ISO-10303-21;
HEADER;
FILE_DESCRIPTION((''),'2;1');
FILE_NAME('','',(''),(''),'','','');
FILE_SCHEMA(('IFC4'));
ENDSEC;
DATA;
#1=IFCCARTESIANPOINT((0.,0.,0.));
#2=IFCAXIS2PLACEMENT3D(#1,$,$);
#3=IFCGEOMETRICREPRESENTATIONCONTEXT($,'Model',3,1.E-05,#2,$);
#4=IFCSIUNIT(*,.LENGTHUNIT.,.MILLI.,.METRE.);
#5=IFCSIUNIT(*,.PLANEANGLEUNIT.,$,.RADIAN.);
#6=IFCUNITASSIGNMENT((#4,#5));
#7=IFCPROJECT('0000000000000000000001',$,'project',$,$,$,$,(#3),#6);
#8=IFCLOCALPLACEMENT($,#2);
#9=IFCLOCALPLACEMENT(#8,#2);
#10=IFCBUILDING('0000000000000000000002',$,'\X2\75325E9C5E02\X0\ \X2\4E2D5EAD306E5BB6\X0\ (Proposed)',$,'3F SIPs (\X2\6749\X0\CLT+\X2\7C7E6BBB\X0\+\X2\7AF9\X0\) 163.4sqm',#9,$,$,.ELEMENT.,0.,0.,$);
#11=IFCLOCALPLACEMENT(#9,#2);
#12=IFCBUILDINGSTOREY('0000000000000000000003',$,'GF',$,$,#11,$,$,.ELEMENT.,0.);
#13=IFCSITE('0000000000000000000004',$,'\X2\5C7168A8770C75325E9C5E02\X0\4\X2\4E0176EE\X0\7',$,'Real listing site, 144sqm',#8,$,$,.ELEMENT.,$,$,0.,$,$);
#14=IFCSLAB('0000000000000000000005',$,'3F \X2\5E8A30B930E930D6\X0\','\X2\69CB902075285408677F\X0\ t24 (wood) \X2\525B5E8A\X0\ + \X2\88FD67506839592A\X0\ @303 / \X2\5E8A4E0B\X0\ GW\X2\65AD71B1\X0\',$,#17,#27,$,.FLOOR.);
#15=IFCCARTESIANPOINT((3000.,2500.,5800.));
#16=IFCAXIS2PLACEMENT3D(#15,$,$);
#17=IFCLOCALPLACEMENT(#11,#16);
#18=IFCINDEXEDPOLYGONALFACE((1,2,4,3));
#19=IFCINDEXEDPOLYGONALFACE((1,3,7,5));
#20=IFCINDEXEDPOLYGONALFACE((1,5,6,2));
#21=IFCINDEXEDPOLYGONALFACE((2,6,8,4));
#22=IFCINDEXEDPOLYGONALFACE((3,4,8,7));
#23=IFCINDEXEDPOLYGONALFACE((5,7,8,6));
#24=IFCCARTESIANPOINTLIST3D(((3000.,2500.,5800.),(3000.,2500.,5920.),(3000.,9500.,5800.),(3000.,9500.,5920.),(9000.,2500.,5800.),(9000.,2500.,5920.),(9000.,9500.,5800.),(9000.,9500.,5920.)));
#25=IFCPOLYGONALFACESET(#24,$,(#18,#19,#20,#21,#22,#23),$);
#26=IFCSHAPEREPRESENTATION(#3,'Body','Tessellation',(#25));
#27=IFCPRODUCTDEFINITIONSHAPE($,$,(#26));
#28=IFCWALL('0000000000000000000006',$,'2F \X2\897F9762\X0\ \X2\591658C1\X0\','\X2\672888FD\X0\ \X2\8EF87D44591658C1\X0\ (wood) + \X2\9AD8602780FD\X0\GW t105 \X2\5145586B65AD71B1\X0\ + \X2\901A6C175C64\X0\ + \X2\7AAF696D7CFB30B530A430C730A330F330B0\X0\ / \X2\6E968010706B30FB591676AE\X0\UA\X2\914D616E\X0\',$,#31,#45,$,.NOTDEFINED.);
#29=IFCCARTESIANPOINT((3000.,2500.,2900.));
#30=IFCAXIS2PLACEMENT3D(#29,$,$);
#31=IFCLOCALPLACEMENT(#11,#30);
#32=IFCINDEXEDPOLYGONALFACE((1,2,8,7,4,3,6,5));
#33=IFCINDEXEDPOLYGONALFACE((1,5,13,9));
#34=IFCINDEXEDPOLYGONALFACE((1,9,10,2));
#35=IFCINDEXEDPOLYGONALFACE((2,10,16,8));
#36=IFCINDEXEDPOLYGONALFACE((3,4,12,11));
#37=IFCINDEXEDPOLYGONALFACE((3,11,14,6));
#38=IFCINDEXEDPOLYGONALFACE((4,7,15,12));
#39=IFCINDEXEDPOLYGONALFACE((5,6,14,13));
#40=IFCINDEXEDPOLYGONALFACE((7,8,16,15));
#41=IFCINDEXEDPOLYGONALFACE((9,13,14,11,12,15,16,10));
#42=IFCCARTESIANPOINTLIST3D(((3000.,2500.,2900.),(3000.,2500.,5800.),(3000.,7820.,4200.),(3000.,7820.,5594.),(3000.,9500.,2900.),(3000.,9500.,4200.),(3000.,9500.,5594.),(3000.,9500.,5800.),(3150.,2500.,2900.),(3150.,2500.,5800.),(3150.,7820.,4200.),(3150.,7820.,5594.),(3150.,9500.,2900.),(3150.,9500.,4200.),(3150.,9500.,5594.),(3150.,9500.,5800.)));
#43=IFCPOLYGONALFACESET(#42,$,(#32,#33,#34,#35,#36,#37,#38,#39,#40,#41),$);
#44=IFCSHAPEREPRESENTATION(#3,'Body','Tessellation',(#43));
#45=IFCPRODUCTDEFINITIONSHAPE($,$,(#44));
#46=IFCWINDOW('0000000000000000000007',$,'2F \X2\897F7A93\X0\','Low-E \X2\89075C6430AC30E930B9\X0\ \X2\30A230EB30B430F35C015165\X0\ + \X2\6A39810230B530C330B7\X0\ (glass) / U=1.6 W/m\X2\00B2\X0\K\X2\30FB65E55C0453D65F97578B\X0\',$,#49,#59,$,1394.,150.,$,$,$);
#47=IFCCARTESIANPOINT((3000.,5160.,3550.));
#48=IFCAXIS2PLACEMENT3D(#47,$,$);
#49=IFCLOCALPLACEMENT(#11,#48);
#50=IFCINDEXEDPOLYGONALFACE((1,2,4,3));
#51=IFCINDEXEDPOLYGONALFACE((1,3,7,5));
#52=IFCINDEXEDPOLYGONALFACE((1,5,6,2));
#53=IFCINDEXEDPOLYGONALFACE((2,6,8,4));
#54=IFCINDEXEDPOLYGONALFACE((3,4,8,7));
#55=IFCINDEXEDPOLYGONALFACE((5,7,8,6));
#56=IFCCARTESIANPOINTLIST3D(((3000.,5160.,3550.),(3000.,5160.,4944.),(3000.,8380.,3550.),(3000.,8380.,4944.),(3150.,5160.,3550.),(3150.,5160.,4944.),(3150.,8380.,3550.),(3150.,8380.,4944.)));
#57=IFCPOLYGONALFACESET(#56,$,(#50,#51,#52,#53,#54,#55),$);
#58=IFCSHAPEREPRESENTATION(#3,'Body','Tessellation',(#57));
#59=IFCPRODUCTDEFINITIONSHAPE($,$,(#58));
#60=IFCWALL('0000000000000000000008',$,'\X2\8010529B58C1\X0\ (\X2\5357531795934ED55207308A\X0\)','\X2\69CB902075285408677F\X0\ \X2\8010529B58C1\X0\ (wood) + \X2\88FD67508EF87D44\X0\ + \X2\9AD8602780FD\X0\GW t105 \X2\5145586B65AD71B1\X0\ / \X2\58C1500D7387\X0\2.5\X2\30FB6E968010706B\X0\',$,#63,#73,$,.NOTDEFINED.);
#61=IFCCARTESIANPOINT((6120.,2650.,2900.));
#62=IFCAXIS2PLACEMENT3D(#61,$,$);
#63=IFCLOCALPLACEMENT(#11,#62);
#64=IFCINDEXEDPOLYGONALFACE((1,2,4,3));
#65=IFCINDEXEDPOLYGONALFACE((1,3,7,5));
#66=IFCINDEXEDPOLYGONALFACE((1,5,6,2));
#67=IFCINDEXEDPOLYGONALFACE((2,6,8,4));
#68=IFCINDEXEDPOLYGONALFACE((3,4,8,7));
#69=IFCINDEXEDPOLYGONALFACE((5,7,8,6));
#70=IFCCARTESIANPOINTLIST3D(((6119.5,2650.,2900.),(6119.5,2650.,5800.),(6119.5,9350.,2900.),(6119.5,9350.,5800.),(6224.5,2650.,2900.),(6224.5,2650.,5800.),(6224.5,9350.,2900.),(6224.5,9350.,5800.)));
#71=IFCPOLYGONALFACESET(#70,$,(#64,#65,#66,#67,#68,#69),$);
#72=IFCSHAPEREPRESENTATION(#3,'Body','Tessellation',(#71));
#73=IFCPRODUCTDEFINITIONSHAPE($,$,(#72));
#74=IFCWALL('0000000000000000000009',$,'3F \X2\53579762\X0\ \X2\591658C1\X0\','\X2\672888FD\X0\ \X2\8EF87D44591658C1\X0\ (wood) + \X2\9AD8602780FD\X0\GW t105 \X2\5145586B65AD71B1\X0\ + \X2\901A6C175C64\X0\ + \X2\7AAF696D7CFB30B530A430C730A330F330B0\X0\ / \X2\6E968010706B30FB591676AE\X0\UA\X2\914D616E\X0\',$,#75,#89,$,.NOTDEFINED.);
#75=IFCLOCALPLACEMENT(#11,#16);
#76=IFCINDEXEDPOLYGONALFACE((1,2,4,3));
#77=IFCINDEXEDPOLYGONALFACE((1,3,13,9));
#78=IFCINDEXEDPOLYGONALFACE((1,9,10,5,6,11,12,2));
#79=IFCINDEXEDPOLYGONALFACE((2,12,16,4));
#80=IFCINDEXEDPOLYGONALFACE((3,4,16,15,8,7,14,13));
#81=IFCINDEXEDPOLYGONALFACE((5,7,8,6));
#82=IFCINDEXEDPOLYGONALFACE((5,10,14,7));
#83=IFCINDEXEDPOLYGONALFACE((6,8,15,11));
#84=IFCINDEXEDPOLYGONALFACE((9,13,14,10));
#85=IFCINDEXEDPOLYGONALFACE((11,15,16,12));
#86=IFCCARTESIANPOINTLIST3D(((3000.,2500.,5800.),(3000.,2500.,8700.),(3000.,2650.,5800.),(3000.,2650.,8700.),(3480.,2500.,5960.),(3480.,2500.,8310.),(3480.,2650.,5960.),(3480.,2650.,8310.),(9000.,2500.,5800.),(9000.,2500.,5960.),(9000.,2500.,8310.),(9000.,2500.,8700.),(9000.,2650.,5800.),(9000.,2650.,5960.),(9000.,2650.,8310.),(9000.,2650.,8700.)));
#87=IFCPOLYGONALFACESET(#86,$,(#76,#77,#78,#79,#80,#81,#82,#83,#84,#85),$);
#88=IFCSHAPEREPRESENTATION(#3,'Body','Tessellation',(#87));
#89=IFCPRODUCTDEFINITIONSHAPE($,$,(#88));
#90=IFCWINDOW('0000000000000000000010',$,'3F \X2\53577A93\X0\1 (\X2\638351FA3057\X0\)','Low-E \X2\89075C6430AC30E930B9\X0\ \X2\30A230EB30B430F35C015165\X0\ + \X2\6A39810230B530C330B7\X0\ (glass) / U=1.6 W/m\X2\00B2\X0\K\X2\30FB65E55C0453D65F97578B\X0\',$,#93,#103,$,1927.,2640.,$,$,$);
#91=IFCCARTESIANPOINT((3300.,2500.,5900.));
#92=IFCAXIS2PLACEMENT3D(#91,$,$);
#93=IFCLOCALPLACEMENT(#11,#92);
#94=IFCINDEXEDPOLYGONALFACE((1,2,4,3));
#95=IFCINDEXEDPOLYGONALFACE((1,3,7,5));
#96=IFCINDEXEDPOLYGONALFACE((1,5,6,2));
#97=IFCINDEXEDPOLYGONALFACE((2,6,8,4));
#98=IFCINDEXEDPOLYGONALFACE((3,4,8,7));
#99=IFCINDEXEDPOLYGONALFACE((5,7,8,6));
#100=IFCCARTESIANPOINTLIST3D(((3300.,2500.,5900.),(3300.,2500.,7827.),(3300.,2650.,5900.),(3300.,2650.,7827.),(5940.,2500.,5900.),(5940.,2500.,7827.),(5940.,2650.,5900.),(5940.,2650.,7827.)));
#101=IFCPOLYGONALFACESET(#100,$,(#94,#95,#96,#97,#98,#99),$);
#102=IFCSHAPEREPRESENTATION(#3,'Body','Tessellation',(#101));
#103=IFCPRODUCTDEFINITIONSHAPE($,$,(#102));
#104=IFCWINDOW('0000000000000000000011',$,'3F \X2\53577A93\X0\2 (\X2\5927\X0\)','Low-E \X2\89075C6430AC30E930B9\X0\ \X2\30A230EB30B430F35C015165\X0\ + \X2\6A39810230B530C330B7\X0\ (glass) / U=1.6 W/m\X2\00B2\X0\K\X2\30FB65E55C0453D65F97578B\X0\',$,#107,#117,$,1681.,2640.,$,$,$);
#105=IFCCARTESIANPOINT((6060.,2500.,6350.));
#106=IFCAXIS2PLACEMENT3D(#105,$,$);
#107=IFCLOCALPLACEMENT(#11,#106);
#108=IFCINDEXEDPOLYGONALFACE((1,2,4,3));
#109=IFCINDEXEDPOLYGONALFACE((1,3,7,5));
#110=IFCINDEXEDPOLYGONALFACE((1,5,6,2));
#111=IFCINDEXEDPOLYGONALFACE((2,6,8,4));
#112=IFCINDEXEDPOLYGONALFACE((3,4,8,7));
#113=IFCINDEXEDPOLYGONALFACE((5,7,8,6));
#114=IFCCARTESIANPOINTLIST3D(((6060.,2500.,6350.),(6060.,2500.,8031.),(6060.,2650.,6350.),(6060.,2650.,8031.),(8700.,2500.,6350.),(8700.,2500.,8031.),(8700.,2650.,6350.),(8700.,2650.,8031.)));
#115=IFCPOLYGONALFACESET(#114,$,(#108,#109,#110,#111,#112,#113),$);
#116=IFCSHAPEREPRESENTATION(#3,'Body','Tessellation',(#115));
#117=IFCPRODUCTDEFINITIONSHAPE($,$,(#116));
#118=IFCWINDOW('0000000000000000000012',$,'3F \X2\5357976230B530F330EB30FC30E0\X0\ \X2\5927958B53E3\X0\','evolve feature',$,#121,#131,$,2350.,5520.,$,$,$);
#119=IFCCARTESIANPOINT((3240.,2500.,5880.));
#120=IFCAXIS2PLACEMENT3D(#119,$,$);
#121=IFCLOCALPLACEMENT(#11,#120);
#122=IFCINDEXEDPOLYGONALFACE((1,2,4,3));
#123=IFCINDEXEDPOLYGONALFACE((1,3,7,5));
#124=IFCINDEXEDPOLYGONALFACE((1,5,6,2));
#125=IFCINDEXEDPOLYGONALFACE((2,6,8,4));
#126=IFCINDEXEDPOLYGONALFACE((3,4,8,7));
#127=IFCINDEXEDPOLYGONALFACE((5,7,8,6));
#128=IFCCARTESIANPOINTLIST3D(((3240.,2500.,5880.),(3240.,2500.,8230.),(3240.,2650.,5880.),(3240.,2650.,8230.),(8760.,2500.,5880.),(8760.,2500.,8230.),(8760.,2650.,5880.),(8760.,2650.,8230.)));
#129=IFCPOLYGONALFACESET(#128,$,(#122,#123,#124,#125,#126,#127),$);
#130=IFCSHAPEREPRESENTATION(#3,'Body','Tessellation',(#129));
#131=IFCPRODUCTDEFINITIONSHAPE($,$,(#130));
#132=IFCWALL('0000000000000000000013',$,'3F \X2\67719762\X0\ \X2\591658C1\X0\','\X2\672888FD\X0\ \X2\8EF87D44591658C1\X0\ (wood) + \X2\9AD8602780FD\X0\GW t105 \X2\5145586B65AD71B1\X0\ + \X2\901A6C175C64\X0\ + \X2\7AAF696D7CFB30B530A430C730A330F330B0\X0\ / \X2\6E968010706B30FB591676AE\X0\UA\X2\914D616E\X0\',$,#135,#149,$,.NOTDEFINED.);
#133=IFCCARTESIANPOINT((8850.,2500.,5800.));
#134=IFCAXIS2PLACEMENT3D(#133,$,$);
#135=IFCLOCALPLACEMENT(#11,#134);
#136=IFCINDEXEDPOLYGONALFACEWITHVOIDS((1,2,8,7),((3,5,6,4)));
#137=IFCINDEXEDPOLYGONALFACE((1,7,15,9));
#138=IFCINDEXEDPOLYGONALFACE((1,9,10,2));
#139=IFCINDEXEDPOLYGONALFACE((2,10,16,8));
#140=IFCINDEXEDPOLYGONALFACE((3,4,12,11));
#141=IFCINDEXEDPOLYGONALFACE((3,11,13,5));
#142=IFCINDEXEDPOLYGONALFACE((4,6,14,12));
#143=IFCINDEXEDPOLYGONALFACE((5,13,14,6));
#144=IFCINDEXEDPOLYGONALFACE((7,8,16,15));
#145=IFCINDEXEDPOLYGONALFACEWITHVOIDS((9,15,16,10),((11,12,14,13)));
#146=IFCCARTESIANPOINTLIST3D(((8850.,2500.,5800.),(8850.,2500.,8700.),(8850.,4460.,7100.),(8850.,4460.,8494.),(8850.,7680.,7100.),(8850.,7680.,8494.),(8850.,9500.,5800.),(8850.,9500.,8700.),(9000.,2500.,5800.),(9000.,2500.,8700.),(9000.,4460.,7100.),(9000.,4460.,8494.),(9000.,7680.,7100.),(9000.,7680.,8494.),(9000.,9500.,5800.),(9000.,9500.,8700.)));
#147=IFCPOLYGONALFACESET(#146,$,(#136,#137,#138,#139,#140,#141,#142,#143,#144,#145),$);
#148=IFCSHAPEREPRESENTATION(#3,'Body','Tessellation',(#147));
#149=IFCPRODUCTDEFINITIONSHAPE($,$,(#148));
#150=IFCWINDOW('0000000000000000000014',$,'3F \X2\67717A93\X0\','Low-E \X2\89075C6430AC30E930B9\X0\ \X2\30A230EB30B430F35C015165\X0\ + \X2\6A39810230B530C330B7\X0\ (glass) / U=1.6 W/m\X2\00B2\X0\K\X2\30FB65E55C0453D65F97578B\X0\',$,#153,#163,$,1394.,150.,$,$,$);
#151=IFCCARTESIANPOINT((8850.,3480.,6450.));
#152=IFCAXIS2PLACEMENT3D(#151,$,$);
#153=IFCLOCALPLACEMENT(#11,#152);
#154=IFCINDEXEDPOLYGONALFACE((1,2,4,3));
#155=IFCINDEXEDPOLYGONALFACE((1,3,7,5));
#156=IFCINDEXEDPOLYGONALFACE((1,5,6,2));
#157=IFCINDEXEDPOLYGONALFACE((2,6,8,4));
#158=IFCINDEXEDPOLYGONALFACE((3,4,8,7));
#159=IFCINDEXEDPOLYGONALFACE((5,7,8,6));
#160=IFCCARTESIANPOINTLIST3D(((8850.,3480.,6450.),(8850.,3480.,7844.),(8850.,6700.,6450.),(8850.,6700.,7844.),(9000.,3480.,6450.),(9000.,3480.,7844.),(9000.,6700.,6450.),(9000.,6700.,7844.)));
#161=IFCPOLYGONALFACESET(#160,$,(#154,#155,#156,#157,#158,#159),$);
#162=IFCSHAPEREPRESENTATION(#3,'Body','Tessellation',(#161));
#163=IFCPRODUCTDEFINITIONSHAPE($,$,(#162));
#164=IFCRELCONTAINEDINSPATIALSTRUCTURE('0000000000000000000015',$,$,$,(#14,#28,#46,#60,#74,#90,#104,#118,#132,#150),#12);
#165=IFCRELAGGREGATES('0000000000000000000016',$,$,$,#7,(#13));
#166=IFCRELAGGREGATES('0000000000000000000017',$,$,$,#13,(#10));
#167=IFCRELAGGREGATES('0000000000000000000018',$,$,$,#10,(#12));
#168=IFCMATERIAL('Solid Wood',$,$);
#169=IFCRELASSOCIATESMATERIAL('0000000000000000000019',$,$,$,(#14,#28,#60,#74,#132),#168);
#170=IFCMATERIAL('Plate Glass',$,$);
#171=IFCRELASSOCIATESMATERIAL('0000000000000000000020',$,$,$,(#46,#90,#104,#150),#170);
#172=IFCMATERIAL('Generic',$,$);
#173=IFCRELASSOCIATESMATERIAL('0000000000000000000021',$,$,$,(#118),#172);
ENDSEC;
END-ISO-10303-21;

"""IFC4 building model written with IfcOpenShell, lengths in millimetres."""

from ifc_helpers import new_model, si_unit, frame, frame_2d, origin, place, context, project, spatial, rectangle, extrude, material, element, fill, save


model = new_model("IFC4")

# Units and contexts
model_context = context("Model", 3, precision=1e-05, world=origin())
ifc_project = project(units=[si_unit("LENGTHUNIT", "METRE", prefix="MILLI"), si_unit("PLANEANGLEUNIT", "RADIAN")], contexts=[model_context])

# Site, building, storey
site_placement = place(None, origin())
site = spatial("IfcSite", under=ifc_project, at=site_placement, Name="山梨県甲府市4丁目7", ObjectType="Real listing site, 144sqm", CompositionType="ELEMENT", RefElevation=0.0)
building_placement = place(site_placement, origin())
building = spatial("IfcBuilding", under=site, at=building_placement, Name="甲府市 中庭の家 (Proposed)", ObjectType="3F SIPs (杉CLT+籾殻+竹) 163.4sqm", CompositionType="ELEMENT", ElevationOfRefHeight=0.0, ElevationOfTerrain=0.0)
storey_placement = place(building_placement, origin())
storey = spatial("IfcBuildingStorey", under=building, at=storey_placement, Name="GF", CompositionType="ELEMENT", Elevation=0.0)

# Slab
ifc_material_1 = material(Name="Solid Wood")
slab_placement = place(storey_placement, frame((3000.0, 2500.0, 5800.0)))
element("IfcSlab", 1, at=slab_placement, inside=storey, material=ifc_material_1, Name="3F 床スラブ", Description="構造用合板 t24 (wood) 剛床 + 製材根太 @303 / 床下 GW断熱", PredefinedType="FLOOR", context=model_context, shape_type="SweptSolid", body=[
    extrude(rectangle(XDim=6000.0, YDim=7000.0, at=frame_2d((3000.0, 3500.0))), frame((3000.0, 2500.0, 5800.0)), (0.0, 0.0, 1.0), 120.0),
])

# Wall, opening, window
wall_1_placement = place(storey_placement, frame((3000.0, 2500.0, 2900.0)))
wall_1 = element("IfcWall", 2, at=wall_1_placement, inside=storey, material=ifc_material_1, Name="2F 西面 外壁", Description="木製 軸組外壁 (wood) + 高性能GW t105 充填断熱 + 通気層 + 窯業系サイディング / 準耐火・外皮UA配慮", PredefinedType="NOTDEFINED", context=model_context, shape_type="SweptSolid", body=[
    extrude(rectangle(XDim=150.0, YDim=7000.0, at=frame_2d((75.0, 3500.0))), frame((3000.0, 2500.0, 2900.0)), (0.0, 0.0, 1.0), 2900.0),
])
opening_1_placement = place(storey_placement, frame((3000.0, 5160.0, 3550.0)))
opening_1 = element("IfcOpeningElement", 3, at=opening_1_placement, cuts=wall_1, PredefinedType="NOTDEFINED", context=model_context, shape_type="SweptSolid", body=[
    extrude(rectangle(XDim=150.0, YDim=3220.0, at=frame_2d((75.0, 1610.0))), frame((3000.0, 5160.0, 3550.0)), (0.0, 0.0, 1.0), 1394.0),
])
ifc_material_2 = material(Name="Plate Glass")
window_1_placement = place(storey_placement, frame((3000.0, 5160.0, 3550.0)))
window_1 = element("IfcWindow", 4, at=window_1_placement, inside=storey, material=ifc_material_2, Name="2F 西窓", Description="Low-E 複層ガラス アルゴン封入 + 樹脂サッシ (glass) / U=1.6 W/m²K・日射取得型", OverallHeight=1394.0, OverallWidth=150.0, context=model_context, shape_type="SweptSolid", body=[
    extrude(rectangle(XDim=150.0, YDim=3220.0, at=frame_2d((75.0, 1610.0))), frame((3000.0, 5160.0, 3550.0)), (0.0, 0.0, 1.0), 1394.0),
])
fill(opening_1, window_1)

# Wall
wall_2_placement = place(storey_placement, frame((6120.0, 2650.0, 2900.0)))
element("IfcWall", 5, at=wall_2_placement, inside=storey, material=ifc_material_1, Name="耐力壁 (南北間仕切り)", Description="構造用合板 耐力壁 (wood) + 製材軸組 + 高性能GW t105 充填断熱 / 壁倍率2.5・準耐火", PredefinedType="NOTDEFINED", context=model_context, shape_type="SweptSolid", body=[
    extrude(rectangle(XDim=105.0, YDim=6700.0, at=frame_2d((52.0, 3350.0))), frame((6120.0, 2650.0, 2900.0)), (0.0, 0.0, 1.0), 2900.0),
])

# Wall, openings, windows
wall_3_placement = place(storey_placement, frame((3000.0, 2500.0, 5800.0)))
wall_3 = element("IfcWall", 6, at=wall_3_placement, inside=storey, material=ifc_material_1, Name="3F 南面 外壁", Description="木製 軸組外壁 (wood) + 高性能GW t105 充填断熱 + 通気層 + 窯業系サイディング / 準耐火・外皮UA配慮", PredefinedType="NOTDEFINED", context=model_context, shape_type="SweptSolid", body=[
    extrude(rectangle(XDim=6000.0, YDim=150.0, at=frame_2d((3000.0, 75.0))), frame((3000.0, 2500.0, 5800.0)), (0.0, 0.0, 1.0), 2900.0),
])
opening_2_placement = place(storey_placement, frame((3300.0, 2500.0, 5900.0)))
opening_2 = element("IfcOpeningElement", 7, at=opening_2_placement, cuts=wall_3, PredefinedType="NOTDEFINED", context=model_context, shape_type="SweptSolid", body=[
    extrude(rectangle(XDim=2640.0, YDim=150.0, at=frame_2d((1320.0, 75.0))), frame((3300.0, 2500.0, 5900.0)), (0.0, 0.0, 1.0), 1927.0),
])
opening_3_placement = place(storey_placement, frame((6060.0, 2500.0, 6350.0)))
opening_3 = element("IfcOpeningElement", 8, at=opening_3_placement, cuts=wall_3, PredefinedType="NOTDEFINED", context=model_context, shape_type="SweptSolid", body=[
    extrude(rectangle(XDim=2640.0, YDim=150.0, at=frame_2d((1320.0, 75.0))), frame((6060.0, 2500.0, 6350.0)), (0.0, 0.0, 1.0), 1681.0),
])
opening_4_placement = place(storey_placement, frame((3240.0, 2500.0, 5880.0)))
opening_4 = element("IfcOpeningElement", 9, at=opening_4_placement, cuts=wall_3, PredefinedType="NOTDEFINED", context=model_context, shape_type="SweptSolid", body=[
    extrude(rectangle(XDim=5520.0, YDim=150.0, at=frame_2d((2760.0, 75.0))), frame((3240.0, 2500.0, 5880.0)), (0.0, 0.0, 1.0), 2350.0),
])
window_2_placement = place(storey_placement, frame((3300.0, 2500.0, 5900.0)))
window_2 = element("IfcWindow", 10, at=window_2_placement, inside=storey, material=ifc_material_2, Name="3F 南窓1 (掃出し)", Description="Low-E 複層ガラス アルゴン封入 + 樹脂サッシ (glass) / U=1.6 W/m²K・日射取得型", OverallHeight=1927.0, OverallWidth=2640.0, context=model_context, shape_type="SweptSolid", body=[
    extrude(rectangle(XDim=2640.0, YDim=150.0, at=frame_2d((1320.0, 75.0))), frame((3300.0, 2500.0, 5900.0)), (0.0, 0.0, 1.0), 1927.0),
])
fill(opening_2, window_2)
window_3_placement = place(storey_placement, frame((6060.0, 2500.0, 6350.0)))
window_3 = element("IfcWindow", 11, at=window_3_placement, inside=storey, material=ifc_material_2, Name="3F 南窓2 (大)", Description="Low-E 複層ガラス アルゴン封入 + 樹脂サッシ (glass) / U=1.6 W/m²K・日射取得型", OverallHeight=1681.0, OverallWidth=2640.0, context=model_context, shape_type="SweptSolid", body=[
    extrude(rectangle(XDim=2640.0, YDim=150.0, at=frame_2d((1320.0, 75.0))), frame((6060.0, 2500.0, 6350.0)), (0.0, 0.0, 1.0), 1681.0),
])
fill(opening_3, window_3)
ifc_material_3 = material(Name="Generic")
window_4_placement = place(storey_placement, frame((3240.0, 2500.0, 5880.0)))
window_4 = element("IfcWindow", 12, at=window_4_placement, inside=storey, material=ifc_material_3, Name="3F 南面サンルーム 大開口", Description="evolve feature", OverallHeight=2350.0, OverallWidth=5520.0, context=model_context, shape_type="SweptSolid", body=[
    extrude(rectangle(XDim=5520.0, YDim=150.0, at=frame_2d((2760.0, 75.0))), frame((3240.0, 2500.0, 5880.0)), (0.0, 0.0, 1.0), 2350.0),
])
fill(opening_4, window_4)

# Wall, opening, window
wall_4_placement = place(storey_placement, frame((8850.0, 2500.0, 5800.0)))
wall_4 = element("IfcWall", 13, at=wall_4_placement, inside=storey, material=ifc_material_1, Name="3F 東面 外壁", Description="木製 軸組外壁 (wood) + 高性能GW t105 充填断熱 + 通気層 + 窯業系サイディング / 準耐火・外皮UA配慮", PredefinedType="NOTDEFINED", context=model_context, shape_type="SweptSolid", body=[
    extrude(rectangle(XDim=150.0, YDim=7000.0, at=frame_2d((75.0, 3500.0))), frame((8850.0, 2500.0, 5800.0)), (0.0, 0.0, 1.0), 2900.0),
])
opening_5_placement = place(storey_placement, frame((8850.0, 3480.0, 6450.0)))
opening_5 = element("IfcOpeningElement", 14, at=opening_5_placement, cuts=wall_4, PredefinedType="NOTDEFINED", context=model_context, shape_type="SweptSolid", body=[
    extrude(rectangle(XDim=150.0, YDim=3220.0, at=frame_2d((75.0, 1610.0))), frame((8850.0, 3480.0, 6450.0)), (0.0, 0.0, 1.0), 1394.0),
])
window_5_placement = place(storey_placement, frame((8850.0, 3480.0, 6450.0)))
window_5 = element("IfcWindow", 15, at=window_5_placement, inside=storey, material=ifc_material_2, Name="3F 東窓", Description="Low-E 複層ガラス アルゴン封入 + 樹脂サッシ (glass) / U=1.6 W/m²K・日射取得型", OverallHeight=1394.0, OverallWidth=150.0, context=model_context, shape_type="SweptSolid", body=[
    extrude(rectangle(XDim=150.0, YDim=3220.0, at=frame_2d((75.0, 1610.0))), frame((8850.0, 3480.0, 6450.0)), (0.0, 0.0, 1.0), 1394.0),
])
fill(opening_5, window_5)

save(model, "model.ifc")
